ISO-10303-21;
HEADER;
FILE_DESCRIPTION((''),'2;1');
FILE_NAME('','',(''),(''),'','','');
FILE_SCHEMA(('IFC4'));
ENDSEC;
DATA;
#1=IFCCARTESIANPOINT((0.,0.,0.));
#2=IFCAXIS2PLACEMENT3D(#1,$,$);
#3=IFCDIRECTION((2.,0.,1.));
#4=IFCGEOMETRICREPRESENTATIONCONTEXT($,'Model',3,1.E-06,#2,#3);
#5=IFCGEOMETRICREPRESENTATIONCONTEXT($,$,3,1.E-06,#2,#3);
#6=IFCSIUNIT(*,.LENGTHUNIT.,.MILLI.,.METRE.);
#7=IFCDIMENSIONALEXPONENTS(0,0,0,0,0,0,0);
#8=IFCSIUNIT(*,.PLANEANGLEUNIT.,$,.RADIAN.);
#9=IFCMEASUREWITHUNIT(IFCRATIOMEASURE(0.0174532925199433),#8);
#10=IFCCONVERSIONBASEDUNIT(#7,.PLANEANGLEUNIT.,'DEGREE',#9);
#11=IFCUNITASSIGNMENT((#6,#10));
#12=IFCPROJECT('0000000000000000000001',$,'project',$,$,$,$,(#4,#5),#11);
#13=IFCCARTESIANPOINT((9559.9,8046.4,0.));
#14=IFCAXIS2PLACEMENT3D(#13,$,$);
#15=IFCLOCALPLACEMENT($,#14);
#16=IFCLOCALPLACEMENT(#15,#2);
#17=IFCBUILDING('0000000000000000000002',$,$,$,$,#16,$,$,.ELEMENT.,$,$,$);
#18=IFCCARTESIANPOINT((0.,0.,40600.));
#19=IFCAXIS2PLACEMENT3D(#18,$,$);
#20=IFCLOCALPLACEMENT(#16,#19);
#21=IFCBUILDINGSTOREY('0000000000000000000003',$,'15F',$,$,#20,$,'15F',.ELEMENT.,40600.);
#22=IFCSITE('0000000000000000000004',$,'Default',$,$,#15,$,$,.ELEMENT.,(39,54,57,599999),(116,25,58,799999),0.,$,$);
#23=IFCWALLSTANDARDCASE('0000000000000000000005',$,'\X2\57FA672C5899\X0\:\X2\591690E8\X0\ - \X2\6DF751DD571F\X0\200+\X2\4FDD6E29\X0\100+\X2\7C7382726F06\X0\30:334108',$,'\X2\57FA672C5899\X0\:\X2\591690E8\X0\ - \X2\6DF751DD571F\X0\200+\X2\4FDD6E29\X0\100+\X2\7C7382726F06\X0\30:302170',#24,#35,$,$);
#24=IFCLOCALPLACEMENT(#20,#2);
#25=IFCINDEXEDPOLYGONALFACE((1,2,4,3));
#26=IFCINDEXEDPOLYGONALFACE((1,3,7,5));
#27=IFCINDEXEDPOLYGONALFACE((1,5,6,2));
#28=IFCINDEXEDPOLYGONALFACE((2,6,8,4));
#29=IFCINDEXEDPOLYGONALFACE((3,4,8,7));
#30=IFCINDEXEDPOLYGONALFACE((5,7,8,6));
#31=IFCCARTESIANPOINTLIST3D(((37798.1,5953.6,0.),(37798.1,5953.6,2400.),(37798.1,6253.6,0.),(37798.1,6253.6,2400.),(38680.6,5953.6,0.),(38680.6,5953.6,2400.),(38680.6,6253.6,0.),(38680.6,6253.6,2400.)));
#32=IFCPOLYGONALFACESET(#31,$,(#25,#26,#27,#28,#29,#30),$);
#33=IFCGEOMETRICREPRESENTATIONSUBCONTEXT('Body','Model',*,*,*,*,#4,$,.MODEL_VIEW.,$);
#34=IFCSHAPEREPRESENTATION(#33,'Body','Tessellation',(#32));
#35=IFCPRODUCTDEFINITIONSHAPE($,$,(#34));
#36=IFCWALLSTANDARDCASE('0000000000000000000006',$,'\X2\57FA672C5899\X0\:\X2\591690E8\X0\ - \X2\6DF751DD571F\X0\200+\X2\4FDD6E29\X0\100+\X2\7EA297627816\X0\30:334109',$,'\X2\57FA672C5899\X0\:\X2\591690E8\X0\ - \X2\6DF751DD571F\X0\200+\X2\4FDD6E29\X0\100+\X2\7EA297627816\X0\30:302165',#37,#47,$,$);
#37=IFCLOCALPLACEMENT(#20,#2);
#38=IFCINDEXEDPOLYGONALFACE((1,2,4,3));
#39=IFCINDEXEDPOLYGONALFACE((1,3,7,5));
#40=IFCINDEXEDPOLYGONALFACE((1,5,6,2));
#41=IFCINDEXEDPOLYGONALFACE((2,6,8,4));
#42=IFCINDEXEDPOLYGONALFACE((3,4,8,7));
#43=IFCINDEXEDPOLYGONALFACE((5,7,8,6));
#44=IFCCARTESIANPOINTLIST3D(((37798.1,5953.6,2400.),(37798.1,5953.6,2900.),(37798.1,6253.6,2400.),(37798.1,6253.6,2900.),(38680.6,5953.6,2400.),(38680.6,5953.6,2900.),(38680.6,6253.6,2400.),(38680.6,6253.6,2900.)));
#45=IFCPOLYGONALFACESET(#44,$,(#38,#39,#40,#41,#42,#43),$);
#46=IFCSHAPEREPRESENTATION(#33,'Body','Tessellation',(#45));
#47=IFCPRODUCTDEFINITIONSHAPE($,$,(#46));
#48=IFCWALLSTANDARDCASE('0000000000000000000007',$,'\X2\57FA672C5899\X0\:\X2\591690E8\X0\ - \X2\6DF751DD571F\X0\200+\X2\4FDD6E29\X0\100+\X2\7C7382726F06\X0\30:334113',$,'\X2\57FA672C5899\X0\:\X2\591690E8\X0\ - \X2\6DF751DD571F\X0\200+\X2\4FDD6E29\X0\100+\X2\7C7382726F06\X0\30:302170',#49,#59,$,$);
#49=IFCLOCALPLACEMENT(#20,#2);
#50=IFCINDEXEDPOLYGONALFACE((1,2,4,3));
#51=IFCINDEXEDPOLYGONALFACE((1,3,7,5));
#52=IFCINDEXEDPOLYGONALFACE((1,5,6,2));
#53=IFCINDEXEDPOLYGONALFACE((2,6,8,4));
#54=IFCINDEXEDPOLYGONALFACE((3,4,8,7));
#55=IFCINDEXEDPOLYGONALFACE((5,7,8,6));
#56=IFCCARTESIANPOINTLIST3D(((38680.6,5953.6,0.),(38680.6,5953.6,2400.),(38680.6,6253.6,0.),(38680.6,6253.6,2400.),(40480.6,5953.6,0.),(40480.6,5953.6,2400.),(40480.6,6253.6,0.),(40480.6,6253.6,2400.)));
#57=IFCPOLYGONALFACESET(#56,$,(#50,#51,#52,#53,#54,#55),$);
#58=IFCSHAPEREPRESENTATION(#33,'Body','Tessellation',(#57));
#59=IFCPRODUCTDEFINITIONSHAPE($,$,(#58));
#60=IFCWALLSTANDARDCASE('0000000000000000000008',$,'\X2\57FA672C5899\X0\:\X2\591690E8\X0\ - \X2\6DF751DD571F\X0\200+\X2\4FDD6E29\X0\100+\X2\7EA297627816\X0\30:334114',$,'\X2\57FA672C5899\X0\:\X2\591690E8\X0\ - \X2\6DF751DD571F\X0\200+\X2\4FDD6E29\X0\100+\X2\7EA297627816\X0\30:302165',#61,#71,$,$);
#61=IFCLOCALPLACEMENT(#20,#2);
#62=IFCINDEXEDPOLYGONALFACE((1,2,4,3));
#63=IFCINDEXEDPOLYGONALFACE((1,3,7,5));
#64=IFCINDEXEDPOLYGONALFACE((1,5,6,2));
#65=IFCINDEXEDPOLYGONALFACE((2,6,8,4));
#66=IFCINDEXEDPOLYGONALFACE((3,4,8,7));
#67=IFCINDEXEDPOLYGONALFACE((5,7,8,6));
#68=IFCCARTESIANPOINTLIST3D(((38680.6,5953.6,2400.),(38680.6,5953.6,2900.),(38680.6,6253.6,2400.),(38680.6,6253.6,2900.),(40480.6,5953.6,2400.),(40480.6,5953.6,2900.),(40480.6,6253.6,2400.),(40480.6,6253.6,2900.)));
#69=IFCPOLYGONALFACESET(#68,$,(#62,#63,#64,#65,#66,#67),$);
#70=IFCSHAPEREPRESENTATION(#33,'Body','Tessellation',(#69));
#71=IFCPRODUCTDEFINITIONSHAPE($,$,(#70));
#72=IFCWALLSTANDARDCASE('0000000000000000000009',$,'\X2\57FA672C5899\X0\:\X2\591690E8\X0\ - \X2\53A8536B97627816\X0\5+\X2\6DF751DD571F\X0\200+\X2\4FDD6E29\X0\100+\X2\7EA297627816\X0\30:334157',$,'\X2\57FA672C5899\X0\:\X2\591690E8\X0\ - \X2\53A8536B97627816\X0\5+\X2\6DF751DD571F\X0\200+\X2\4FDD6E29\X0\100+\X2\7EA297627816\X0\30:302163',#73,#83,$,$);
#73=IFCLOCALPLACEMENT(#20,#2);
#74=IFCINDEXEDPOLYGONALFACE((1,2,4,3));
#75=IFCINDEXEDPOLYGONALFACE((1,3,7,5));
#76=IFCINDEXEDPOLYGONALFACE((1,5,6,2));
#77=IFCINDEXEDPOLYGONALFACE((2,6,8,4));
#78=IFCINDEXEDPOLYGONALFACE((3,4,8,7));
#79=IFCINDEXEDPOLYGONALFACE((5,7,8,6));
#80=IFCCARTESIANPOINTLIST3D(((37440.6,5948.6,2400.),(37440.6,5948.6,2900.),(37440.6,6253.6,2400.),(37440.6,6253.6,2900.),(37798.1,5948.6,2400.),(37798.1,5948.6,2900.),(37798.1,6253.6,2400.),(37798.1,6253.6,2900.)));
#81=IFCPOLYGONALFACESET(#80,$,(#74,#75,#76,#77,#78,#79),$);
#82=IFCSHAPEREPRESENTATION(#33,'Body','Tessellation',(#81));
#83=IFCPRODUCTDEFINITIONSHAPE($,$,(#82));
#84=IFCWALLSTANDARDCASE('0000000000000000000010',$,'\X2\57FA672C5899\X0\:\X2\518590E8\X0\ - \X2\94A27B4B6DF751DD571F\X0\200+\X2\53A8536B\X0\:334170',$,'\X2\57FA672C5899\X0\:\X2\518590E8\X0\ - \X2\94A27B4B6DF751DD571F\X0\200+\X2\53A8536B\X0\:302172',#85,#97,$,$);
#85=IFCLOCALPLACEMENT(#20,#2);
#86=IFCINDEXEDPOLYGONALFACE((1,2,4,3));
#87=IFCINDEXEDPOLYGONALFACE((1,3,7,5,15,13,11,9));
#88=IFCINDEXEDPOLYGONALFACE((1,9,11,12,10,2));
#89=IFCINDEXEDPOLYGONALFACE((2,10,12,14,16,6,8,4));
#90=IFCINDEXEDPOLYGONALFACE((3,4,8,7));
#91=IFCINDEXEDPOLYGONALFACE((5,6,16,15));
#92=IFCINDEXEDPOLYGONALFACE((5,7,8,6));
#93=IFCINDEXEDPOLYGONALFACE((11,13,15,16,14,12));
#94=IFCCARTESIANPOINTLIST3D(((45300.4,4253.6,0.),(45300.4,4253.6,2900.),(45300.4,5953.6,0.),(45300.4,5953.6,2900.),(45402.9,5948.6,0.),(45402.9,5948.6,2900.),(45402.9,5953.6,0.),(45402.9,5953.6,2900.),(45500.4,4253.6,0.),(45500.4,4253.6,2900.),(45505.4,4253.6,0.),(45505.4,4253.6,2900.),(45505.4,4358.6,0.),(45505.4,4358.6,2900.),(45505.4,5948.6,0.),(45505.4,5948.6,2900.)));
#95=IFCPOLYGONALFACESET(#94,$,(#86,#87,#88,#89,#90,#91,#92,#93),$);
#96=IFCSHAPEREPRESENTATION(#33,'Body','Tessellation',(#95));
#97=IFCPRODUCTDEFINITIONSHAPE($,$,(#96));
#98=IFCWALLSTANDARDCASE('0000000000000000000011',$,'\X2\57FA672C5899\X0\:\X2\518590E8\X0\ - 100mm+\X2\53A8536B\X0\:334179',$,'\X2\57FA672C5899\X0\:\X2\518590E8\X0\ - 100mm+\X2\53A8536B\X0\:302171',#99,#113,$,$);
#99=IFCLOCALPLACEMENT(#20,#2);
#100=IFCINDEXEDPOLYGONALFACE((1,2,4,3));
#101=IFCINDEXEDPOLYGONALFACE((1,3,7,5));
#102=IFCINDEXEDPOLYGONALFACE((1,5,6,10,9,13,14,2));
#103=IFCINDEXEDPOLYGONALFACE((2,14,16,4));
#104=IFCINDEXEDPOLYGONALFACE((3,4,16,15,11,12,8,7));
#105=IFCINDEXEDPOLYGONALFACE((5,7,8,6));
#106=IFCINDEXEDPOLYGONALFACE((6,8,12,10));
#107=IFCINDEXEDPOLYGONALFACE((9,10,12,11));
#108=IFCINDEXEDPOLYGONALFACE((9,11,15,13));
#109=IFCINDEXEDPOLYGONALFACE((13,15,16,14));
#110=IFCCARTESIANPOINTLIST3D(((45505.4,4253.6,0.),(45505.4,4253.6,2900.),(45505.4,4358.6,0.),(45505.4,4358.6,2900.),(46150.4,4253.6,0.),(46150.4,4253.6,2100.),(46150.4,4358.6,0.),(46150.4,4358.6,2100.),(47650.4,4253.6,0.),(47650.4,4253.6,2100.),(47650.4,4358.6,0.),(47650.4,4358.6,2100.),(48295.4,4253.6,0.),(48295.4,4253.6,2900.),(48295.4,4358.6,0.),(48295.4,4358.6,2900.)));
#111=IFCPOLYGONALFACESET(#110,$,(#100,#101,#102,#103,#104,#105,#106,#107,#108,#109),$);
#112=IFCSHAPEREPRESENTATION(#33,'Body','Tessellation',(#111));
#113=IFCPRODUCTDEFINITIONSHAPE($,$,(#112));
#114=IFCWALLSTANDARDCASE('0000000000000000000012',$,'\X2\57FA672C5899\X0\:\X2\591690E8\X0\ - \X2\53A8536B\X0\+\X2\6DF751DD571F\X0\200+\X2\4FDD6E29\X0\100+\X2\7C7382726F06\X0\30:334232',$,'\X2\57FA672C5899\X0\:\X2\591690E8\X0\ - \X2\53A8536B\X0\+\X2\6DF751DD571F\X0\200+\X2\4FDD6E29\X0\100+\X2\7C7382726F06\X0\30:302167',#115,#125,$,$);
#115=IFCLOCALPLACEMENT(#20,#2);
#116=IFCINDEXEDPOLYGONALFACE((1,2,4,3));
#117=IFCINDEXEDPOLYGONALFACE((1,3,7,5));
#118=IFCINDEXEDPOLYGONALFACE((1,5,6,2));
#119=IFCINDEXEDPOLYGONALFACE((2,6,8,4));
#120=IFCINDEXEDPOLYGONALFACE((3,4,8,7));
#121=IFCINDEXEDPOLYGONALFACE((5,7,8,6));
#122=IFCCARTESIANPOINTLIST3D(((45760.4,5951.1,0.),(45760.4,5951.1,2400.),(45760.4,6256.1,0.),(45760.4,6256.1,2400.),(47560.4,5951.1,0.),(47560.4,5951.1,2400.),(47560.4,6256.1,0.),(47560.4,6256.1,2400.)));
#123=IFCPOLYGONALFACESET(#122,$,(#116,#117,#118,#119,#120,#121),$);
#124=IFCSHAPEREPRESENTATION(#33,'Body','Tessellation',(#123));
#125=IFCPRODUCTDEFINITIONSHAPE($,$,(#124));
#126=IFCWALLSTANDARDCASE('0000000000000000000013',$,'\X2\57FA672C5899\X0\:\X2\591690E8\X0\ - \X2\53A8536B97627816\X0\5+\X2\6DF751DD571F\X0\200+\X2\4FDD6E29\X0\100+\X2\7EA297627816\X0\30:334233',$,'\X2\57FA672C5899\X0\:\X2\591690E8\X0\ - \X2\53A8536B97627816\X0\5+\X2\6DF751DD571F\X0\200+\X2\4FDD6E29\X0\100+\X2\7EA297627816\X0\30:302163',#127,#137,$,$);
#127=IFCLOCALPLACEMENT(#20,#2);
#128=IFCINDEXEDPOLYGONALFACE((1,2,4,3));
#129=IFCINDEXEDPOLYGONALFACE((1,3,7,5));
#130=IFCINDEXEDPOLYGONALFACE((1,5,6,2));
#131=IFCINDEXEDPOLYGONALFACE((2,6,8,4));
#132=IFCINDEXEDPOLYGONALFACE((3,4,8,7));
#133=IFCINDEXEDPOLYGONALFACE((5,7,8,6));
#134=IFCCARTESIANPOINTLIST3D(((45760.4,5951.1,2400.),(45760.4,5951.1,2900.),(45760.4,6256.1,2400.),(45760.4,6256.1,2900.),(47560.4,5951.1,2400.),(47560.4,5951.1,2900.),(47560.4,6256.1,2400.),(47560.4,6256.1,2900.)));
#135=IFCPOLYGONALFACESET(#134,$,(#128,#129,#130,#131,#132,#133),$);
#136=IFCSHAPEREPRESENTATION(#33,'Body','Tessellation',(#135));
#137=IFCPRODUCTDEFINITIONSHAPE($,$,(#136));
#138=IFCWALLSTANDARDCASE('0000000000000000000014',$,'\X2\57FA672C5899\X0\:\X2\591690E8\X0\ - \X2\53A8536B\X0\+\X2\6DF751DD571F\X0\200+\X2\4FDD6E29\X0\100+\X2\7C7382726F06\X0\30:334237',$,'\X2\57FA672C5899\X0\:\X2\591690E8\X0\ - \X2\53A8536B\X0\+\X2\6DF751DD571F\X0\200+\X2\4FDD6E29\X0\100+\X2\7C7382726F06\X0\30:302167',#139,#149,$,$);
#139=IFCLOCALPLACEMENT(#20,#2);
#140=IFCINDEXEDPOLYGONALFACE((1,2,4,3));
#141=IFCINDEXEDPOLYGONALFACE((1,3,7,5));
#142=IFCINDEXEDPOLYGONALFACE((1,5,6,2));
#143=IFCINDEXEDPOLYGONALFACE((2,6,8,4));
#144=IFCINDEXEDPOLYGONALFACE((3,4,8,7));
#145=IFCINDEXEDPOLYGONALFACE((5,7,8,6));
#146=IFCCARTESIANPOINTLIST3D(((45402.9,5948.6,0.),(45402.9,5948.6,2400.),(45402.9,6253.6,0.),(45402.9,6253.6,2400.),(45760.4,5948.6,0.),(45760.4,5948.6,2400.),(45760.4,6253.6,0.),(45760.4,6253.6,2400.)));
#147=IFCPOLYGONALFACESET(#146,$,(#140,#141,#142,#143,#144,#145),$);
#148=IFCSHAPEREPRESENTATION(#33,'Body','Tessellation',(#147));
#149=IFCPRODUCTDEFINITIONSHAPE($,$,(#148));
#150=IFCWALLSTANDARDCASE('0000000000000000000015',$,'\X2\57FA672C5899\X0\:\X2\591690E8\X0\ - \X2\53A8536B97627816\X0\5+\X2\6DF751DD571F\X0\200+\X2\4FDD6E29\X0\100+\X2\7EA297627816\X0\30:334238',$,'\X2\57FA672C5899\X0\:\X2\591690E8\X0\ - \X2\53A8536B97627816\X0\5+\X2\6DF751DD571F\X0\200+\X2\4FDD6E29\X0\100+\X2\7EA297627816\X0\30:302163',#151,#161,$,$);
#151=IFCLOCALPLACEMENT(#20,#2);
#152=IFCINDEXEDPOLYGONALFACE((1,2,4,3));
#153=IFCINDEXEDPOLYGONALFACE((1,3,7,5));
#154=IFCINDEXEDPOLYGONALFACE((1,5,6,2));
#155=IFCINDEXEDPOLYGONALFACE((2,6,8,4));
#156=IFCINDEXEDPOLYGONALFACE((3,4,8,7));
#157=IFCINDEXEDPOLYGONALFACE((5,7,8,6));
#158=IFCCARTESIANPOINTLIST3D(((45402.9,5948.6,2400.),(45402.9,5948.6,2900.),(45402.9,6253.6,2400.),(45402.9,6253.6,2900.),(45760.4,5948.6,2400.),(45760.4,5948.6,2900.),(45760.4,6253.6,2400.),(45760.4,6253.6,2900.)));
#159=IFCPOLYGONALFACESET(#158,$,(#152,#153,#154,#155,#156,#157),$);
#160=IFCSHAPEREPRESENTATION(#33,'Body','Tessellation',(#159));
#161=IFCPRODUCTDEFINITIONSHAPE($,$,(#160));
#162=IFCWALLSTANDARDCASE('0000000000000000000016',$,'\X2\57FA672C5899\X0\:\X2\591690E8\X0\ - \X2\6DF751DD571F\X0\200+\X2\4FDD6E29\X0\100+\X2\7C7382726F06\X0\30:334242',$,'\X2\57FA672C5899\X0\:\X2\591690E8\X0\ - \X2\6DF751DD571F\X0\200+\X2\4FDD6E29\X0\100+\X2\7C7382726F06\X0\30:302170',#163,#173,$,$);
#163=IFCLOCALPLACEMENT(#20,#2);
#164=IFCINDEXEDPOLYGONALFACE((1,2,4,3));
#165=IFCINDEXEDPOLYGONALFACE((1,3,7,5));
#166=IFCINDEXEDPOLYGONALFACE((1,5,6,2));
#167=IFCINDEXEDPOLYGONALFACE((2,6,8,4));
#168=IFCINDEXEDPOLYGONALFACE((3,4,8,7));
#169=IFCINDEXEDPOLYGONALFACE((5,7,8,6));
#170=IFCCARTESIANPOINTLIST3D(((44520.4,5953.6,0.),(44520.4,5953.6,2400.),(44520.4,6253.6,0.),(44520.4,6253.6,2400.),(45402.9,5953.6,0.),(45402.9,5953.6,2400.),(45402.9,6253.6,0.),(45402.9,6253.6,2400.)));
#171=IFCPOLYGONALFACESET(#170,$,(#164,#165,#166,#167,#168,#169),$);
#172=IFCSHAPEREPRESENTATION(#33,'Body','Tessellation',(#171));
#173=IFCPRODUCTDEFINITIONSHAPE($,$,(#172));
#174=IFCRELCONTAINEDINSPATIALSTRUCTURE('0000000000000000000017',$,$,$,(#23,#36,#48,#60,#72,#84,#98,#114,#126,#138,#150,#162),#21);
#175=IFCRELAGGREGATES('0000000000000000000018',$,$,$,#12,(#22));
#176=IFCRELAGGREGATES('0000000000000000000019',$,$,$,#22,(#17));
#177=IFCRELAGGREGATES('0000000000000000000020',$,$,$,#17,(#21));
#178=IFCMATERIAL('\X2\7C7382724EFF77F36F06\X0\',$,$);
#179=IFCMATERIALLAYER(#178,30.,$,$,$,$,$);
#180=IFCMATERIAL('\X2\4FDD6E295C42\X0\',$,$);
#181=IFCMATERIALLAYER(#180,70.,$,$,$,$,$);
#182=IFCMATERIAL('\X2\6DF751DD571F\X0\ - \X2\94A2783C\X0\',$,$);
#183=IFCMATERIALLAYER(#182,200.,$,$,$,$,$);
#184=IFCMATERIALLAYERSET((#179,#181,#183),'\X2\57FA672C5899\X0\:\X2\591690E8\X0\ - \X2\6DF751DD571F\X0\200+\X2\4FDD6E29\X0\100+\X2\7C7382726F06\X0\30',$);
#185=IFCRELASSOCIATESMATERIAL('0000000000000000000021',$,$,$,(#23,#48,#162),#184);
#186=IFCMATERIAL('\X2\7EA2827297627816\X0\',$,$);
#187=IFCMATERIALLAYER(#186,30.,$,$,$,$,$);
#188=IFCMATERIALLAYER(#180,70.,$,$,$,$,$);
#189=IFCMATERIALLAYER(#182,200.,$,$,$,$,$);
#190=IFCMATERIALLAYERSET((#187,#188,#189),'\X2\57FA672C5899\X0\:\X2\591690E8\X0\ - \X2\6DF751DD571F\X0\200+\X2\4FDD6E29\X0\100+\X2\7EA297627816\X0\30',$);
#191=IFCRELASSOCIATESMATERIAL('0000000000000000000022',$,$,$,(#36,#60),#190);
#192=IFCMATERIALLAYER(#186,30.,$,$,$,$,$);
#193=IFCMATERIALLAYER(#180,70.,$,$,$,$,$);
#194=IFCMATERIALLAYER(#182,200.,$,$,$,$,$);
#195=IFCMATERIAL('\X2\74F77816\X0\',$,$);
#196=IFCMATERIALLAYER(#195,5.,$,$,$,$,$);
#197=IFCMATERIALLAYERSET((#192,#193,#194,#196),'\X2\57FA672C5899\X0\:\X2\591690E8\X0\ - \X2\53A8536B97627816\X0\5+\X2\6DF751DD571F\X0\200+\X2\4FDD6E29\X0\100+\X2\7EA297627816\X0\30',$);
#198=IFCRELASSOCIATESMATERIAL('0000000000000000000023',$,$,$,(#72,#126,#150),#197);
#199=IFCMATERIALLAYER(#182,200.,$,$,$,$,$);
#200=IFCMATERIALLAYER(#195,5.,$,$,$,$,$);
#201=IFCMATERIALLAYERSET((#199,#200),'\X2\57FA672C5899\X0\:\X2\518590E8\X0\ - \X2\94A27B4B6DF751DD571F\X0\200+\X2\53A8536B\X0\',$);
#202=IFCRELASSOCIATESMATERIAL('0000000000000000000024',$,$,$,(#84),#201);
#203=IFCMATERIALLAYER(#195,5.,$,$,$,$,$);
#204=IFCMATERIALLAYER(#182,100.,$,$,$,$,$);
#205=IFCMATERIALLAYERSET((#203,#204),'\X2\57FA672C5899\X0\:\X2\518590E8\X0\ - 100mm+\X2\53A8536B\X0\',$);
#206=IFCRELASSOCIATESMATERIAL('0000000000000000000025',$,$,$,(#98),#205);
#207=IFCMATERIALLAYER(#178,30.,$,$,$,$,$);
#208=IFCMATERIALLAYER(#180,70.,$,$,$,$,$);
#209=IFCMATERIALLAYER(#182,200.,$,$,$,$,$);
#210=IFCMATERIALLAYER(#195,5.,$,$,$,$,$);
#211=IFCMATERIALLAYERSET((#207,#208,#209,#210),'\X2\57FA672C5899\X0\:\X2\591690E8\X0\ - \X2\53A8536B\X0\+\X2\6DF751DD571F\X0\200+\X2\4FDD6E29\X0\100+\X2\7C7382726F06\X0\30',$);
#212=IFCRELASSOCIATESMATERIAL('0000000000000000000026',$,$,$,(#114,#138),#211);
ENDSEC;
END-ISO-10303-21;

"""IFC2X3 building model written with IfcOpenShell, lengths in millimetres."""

from ifc_helpers import new_model, entity, si_unit, converted_unit, direction, frame, frame_2d, origin, place, context, subcontext, project, spatial, polyline, rectangle, outline, extrude, material, layer, layer_set, layer_usage, element, save


model = new_model("IFC2X3")

# Units and contexts
model_context = context("Model", 3, precision=1e-06, world=origin(), true_north=direction((2.0, 0.0, 1.0)))
context_of_model = context(None, 3, precision=1e-06, world=origin(), true_north=direction((2.0, 0.0, 1.0)))
body_context = subcontext(model_context, "Body", "Model", "MODEL_VIEW")
ifc_project = project(units=[si_unit("LENGTHUNIT", "METRE", prefix="MILLI"), converted_unit("PLANEANGLEUNIT", "DEGREE", entity("IfcRatioMeasure", 0.0174532925199433), si_unit("PLANEANGLEUNIT", "RADIAN"), dimensions=[0, 0, 0, 0, 0, 0, 0])], contexts=[model_context, context_of_model])

# Site, building, storey
site_placement = place(None, frame((9559.9, 8046.4, 0.0)))
site = spatial("IfcSite", under=ifc_project, at=site_placement, Name="Default", CompositionType="ELEMENT", RefLatitude=(39, 54, 57, 599999), RefLongitude=(116, 25, 58, 799999), RefElevation=0.0)
building_placement = place(site_placement, origin())
building = spatial("IfcBuilding", under=site, at=building_placement, CompositionType="ELEMENT")
storey_placement = place(building_placement, frame((0.0, 0.0, 40600.0)))
storey = spatial("IfcBuildingStorey", under=building, at=storey_placement, Name="15F", LongName="15F", CompositionType="ELEMENT", Elevation=40600.0)

# Shared definitions
ifc_material_1 = material(Name="红色面砖")
ifc_layer_1 = layer(ifc_material_1, 30.0)
ifc_material_2 = material(Name="保温层")
ifc_layer_2 = layer(ifc_material_2, 70.0)
ifc_material_3 = material(Name="混凝土 - 钢砼")
ifc_layer_3 = layer(ifc_material_3, 200.0)
ifc_layer_set_1 = layer_set([ifc_layer_1, ifc_layer_2, ifc_layer_3], Name="基本墙:外部 - 混凝土200+保温100+红面砖30")

# Walls
ifc_material_4 = material(Name="米色仿石漆")
ifc_layer_4 = layer(ifc_material_4, 30.0)
ifc_layer_5 = layer(ifc_material_2, 70.0)
ifc_layer_6 = layer(ifc_material_3, 200.0)
ifc_layer_set_2 = layer_set([ifc_layer_4, ifc_layer_5, ifc_layer_6], Name="基本墙:外部 - 混凝土200+保温100+米色漆30")
ifc_layer_usage_1 = layer_usage(ifc_layer_set_2, "AXIS2", "POSITIVE", -150.0)
wall_1_placement = place(storey_placement, frame((38680.6, 6103.6, 0.0), z_axis=(0.0, 0.0, 1.0), x_axis=(-1.0, 0.0, 0.0)))
element("IfcWallStandardCase", 1, at=wall_1_placement, inside=storey, material=ifc_layer_usage_1, Name="基本墙:外部 - 混凝土200+保温100+米色漆30:334108", ObjectType="基本墙:外部 - 混凝土200+保温100+米色漆30:302170", context=body_context, shape_type="SweptSolid", body=[
    extrude(rectangle(XDim=882.5, YDim=300.0, at=frame_2d((441.3, 0.0), x_axis=(-1.0, 0.0))), origin(), (0.0, 0.0, 1.0), 2400.0),
])
ifc_layer_usage_2 = layer_usage(ifc_layer_set_1, "AXIS2", "POSITIVE", -150.0)
wall_2_placement = place(storey_placement, frame((38680.6, 6103.6, 2400.0), z_axis=(0.0, 0.0, 1.0), x_axis=(-1.0, 0.0, 0.0)))
element("IfcWallStandardCase", 2, at=wall_2_placement, inside=storey, material=ifc_layer_usage_2, Name="基本墙:外部 - 混凝土200+保温100+红面砖30:334109", ObjectType="基本墙:外部 - 混凝土200+保温100+红面砖30:302165", context=body_context, shape_type="SweptSolid", body=[
    extrude(rectangle(XDim=882.5, YDim=300.0, at=frame_2d((441.3, 0.0), x_axis=(-1.0, 0.0))), origin(), (0.0, 0.0, 1.0), 500.0),
])
ifc_layer_usage_3 = layer_usage(ifc_layer_set_2, "AXIS2", "POSITIVE", -150.0)
wall_3_placement = place(storey_placement, frame((40480.6, 6103.6, 0.0), z_axis=(0.0, 0.0, 1.0), x_axis=(-1.0, 0.0, 0.0)))
element("IfcWallStandardCase", 3, at=wall_3_placement, inside=storey, material=ifc_layer_usage_3, Name="基本墙:外部 - 混凝土200+保温100+米色漆30:334113", ObjectType="基本墙:外部 - 混凝土200+保温100+米色漆30:302170", context=body_context, shape_type="SweptSolid", body=[
    extrude(rectangle(XDim=1800.0, YDim=300.0, at=frame_2d((900.0, 0.0), x_axis=(-1.0, 0.0))), origin(), (0.0, 0.0, 1.0), 2400.0),
])
ifc_layer_usage_4 = layer_usage(ifc_layer_set_1, "AXIS2", "POSITIVE", -150.0)
wall_4_placement = place(storey_placement, frame((40480.6, 6103.6, 2400.0), z_axis=(0.0, 0.0, 1.0), x_axis=(-1.0, 0.0, 0.0)))
element("IfcWallStandardCase", 4, at=wall_4_placement, inside=storey, material=ifc_layer_usage_4, Name="基本墙:外部 - 混凝土200+保温100+红面砖30:334114", ObjectType="基本墙:外部 - 混凝土200+保温100+红面砖30:302165", context=body_context, shape_type="SweptSolid", body=[
    extrude(rectangle(XDim=1800.0, YDim=300.0, at=frame_2d((900.0, 0.0), x_axis=(-1.0, 0.0))), origin(), (0.0, 0.0, 1.0), 500.0),
])
ifc_layer_7 = layer(ifc_material_1, 30.0)
ifc_layer_8 = layer(ifc_material_2, 70.0)
ifc_layer_9 = layer(ifc_material_3, 200.0)
ifc_material_5 = material(Name="瓷砖")
ifc_layer_10 = layer(ifc_material_5, 5.0)
ifc_layer_set_3 = layer_set([ifc_layer_7, ifc_layer_8, ifc_layer_9, ifc_layer_10], Name="基本墙:外部 - 厨卫面砖5+混凝土200+保温100+红面砖30")
ifc_layer_usage_5 = layer_usage(ifc_layer_set_3, "AXIS2", "POSITIVE", -152.5)
wall_5_placement = place(storey_placement, frame((37798.1, 6101.1, 2400.0), z_axis=(0.0, 0.0, 1.0), x_axis=(-1.0, 0.0, 0.0)))
element("IfcWallStandardCase", 5, at=wall_5_placement, inside=storey, material=ifc_layer_usage_5, Name="基本墙:外部 - 厨卫面砖5+混凝土200+保温100+红面砖30:334157", ObjectType="基本墙:外部 - 厨卫面砖5+混凝土200+保温100+红面砖30:302163", context=body_context, shape_type="SweptSolid", body=[
    extrude(rectangle(XDim=357.5, YDim=305.0, at=frame_2d((178.7, 0.0), x_axis=(-1.0, 0.0))), origin(), (0.0, 0.0, 1.0), 500.0),
])

# Wall
ifc_layer_11 = layer(ifc_material_3, 200.0)
ifc_layer_12 = layer(ifc_material_5, 5.0)
ifc_layer_set_4 = layer_set([ifc_layer_11, ifc_layer_12], Name="基本墙:内部 - 钢筋混凝土200+厨卫")
ifc_layer_usage_6 = layer_usage(ifc_layer_set_4, "AXIS2", "POSITIVE", -102.5)
wall_6_placement = place(storey_placement, frame((45402.9, 5953.6, 0.0), z_axis=(0.0, 0.0, 1.0), x_axis=(0.0, -1.0, 0.0)))
element("IfcWallStandardCase", 6, at=wall_6_placement, inside=storey, material=ifc_layer_usage_6, Name="基本墙:内部 - 钢筋混凝土200+厨卫:334170", ObjectType="基本墙:内部 - 钢筋混凝土200+厨卫:302172", context=body_context, shape_type="SweptSolid", body=[
    extrude(outline(polyline([(1700.0, -102.5), (1700.0, 97.5), (1700.0, 102.5), (1595.0, 102.5), (5.0, 102.5), (5.0, 0.0), (0.0, 0.0), (0.0, -102.5), (1700.0, -102.5)])), origin(), (0.0, 0.0, 1.0), 2900.0),
])

# Wall, opening
ifc_layer_13 = layer(ifc_material_5, 5.0)
ifc_layer_14 = layer(ifc_material_3, 100.0)
ifc_layer_set_5 = layer_set([ifc_layer_13, ifc_layer_14], Name="基本墙:内部 - 100mm+厨卫")
ifc_layer_usage_7 = layer_usage(ifc_layer_set_5, "AXIS2", "NEGATIVE", 52.5)
wall_7_placement = place(storey_placement, frame((45505.4, 4306.1, 0.0)))
wall_7 = element("IfcWallStandardCase", 7, at=wall_7_placement, inside=storey, material=ifc_layer_usage_7, Name="基本墙:内部 - 100mm+厨卫:334179", ObjectType="基本墙:内部 - 100mm+厨卫:302171", context=body_context, shape_type="SweptSolid", body=[
    extrude(rectangle(XDim=2790.0, YDim=105.0, at=frame_2d((1395.0, 0.0), x_axis=(-1.0, 0.0))), origin(), (0.0, 0.0, 1.0), 2900.0),
])
opening_1_placement = place(wall_7_placement, frame((645.0, -52.5, 0.0)))
element("IfcOpeningElement", 8, at=opening_1_placement, cuts=wall_7, ObjectType="Opening", context=body_context, shape_type="SweptSolid", body=[
    extrude(rectangle(XDim=2100.0, YDim=1500.0, at=frame_2d((1050.0, 750.0), x_axis=(1.0, 0.0))), frame((0.0, 0.0, 0.0), z_axis=(0.0, 1.0, 0.0), x_axis=(0.0, 0.0, 1.0)), (0.0, 0.0, 1.0), 105.0),
])

# Walls
ifc_layer_15 = layer(ifc_material_4, 30.0)
ifc_layer_16 = layer(ifc_material_2, 70.0)
ifc_layer_17 = layer(ifc_material_3, 200.0)
ifc_layer_18 = layer(ifc_material_5, 5.0)
ifc_layer_set_6 = layer_set([ifc_layer_15, ifc_layer_16, ifc_layer_17, ifc_layer_18], Name="基本墙:外部 - 厨卫+混凝土200+保温100+米色漆30")
ifc_layer_usage_8 = layer_usage(ifc_layer_set_6, "AXIS2", "NEGATIVE", 152.5)
wall_8_placement = place(storey_placement, frame((45760.4, 6103.6, 0.0)))
element("IfcWallStandardCase", 9, at=wall_8_placement, inside=storey, material=ifc_layer_usage_8, Name="基本墙:外部 - 厨卫+混凝土200+保温100+米色漆30:334232", ObjectType="基本墙:外部 - 厨卫+混凝土200+保温100+米色漆30:302167", context=body_context, shape_type="SweptSolid", body=[
    extrude(rectangle(XDim=1800.0, YDim=305.0, at=frame_2d((900.0, 0.0), x_axis=(-1.0, 0.0))), origin(), (0.0, 0.0, 1.0), 2400.0),
])
ifc_layer_usage_9 = layer_usage(ifc_layer_set_3, "AXIS2", "NEGATIVE", 152.5)
wall_9_placement = place(storey_placement, frame((45760.4, 6103.6, 2400.0)))
element("IfcWallStandardCase", 10, at=wall_9_placement, inside=storey, material=ifc_layer_usage_9, Name="基本墙:外部 - 厨卫面砖5+混凝土200+保温100+红面砖30:334233", ObjectType="基本墙:外部 - 厨卫面砖5+混凝土200+保温100+红面砖30:302163", context=body_context, shape_type="SweptSolid", body=[
    extrude(rectangle(XDim=1800.0, YDim=305.0, at=frame_2d((900.0, 0.0), x_axis=(-1.0, 0.0))), origin(), (0.0, 0.0, 1.0), 500.0),
])
ifc_layer_usage_10 = layer_usage(ifc_layer_set_6, "AXIS2", "NEGATIVE", 152.5)
wall_10_placement = place(storey_placement, frame((45402.9, 6101.1, 0.0)))
element("IfcWallStandardCase", 11, at=wall_10_placement, inside=storey, material=ifc_layer_usage_10, Name="基本墙:外部 - 厨卫+混凝土200+保温100+米色漆30:334237", ObjectType="基本墙:外部 - 厨卫+混凝土200+保温100+米色漆30:302167", context=body_context, shape_type="SweptSolid", body=[
    extrude(rectangle(XDim=357.5, YDim=305.0, at=frame_2d((178.7, 0.0), x_axis=(-1.0, 0.0))), origin(), (0.0, 0.0, 1.0), 2400.0),
])
ifc_layer_usage_11 = layer_usage(ifc_layer_set_3, "AXIS2", "NEGATIVE", 152.5)
wall_11_placement = place(storey_placement, frame((45402.9, 6101.1, 2400.0)))
element("IfcWallStandardCase", 12, at=wall_11_placement, inside=storey, material=ifc_layer_usage_11, Name="基本墙:外部 - 厨卫面砖5+混凝土200+保温100+红面砖30:334238", ObjectType="基本墙:外部 - 厨卫面砖5+混凝土200+保温100+红面砖30:302163", context=body_context, shape_type="SweptSolid", body=[
    extrude(rectangle(XDim=357.5, YDim=305.0, at=frame_2d((178.7, 0.0), x_axis=(-1.0, 0.0))), origin(), (0.0, 0.0, 1.0), 500.0),
])
ifc_layer_usage_12 = layer_usage(ifc_layer_set_2, "AXIS2", "NEGATIVE", 150.0)
wall_12_placement = place(storey_placement, frame((44520.4, 6103.6, 0.0)))
element("IfcWallStandardCase", 13, at=wall_12_placement, inside=storey, material=ifc_layer_usage_12, Name="基本墙:外部 - 混凝土200+保温100+米色漆30:334242", ObjectType="基本墙:外部 - 混凝土200+保温100+米色漆30:302170", context=body_context, shape_type="SweptSolid", body=[
    extrude(rectangle(XDim=882.5, YDim=300.0, at=frame_2d((441.2, 0.0), x_axis=(-1.0, 0.0))), origin(), (0.0, 0.0, 1.0), 2400.0),
])

save(model, "model.ifc")
